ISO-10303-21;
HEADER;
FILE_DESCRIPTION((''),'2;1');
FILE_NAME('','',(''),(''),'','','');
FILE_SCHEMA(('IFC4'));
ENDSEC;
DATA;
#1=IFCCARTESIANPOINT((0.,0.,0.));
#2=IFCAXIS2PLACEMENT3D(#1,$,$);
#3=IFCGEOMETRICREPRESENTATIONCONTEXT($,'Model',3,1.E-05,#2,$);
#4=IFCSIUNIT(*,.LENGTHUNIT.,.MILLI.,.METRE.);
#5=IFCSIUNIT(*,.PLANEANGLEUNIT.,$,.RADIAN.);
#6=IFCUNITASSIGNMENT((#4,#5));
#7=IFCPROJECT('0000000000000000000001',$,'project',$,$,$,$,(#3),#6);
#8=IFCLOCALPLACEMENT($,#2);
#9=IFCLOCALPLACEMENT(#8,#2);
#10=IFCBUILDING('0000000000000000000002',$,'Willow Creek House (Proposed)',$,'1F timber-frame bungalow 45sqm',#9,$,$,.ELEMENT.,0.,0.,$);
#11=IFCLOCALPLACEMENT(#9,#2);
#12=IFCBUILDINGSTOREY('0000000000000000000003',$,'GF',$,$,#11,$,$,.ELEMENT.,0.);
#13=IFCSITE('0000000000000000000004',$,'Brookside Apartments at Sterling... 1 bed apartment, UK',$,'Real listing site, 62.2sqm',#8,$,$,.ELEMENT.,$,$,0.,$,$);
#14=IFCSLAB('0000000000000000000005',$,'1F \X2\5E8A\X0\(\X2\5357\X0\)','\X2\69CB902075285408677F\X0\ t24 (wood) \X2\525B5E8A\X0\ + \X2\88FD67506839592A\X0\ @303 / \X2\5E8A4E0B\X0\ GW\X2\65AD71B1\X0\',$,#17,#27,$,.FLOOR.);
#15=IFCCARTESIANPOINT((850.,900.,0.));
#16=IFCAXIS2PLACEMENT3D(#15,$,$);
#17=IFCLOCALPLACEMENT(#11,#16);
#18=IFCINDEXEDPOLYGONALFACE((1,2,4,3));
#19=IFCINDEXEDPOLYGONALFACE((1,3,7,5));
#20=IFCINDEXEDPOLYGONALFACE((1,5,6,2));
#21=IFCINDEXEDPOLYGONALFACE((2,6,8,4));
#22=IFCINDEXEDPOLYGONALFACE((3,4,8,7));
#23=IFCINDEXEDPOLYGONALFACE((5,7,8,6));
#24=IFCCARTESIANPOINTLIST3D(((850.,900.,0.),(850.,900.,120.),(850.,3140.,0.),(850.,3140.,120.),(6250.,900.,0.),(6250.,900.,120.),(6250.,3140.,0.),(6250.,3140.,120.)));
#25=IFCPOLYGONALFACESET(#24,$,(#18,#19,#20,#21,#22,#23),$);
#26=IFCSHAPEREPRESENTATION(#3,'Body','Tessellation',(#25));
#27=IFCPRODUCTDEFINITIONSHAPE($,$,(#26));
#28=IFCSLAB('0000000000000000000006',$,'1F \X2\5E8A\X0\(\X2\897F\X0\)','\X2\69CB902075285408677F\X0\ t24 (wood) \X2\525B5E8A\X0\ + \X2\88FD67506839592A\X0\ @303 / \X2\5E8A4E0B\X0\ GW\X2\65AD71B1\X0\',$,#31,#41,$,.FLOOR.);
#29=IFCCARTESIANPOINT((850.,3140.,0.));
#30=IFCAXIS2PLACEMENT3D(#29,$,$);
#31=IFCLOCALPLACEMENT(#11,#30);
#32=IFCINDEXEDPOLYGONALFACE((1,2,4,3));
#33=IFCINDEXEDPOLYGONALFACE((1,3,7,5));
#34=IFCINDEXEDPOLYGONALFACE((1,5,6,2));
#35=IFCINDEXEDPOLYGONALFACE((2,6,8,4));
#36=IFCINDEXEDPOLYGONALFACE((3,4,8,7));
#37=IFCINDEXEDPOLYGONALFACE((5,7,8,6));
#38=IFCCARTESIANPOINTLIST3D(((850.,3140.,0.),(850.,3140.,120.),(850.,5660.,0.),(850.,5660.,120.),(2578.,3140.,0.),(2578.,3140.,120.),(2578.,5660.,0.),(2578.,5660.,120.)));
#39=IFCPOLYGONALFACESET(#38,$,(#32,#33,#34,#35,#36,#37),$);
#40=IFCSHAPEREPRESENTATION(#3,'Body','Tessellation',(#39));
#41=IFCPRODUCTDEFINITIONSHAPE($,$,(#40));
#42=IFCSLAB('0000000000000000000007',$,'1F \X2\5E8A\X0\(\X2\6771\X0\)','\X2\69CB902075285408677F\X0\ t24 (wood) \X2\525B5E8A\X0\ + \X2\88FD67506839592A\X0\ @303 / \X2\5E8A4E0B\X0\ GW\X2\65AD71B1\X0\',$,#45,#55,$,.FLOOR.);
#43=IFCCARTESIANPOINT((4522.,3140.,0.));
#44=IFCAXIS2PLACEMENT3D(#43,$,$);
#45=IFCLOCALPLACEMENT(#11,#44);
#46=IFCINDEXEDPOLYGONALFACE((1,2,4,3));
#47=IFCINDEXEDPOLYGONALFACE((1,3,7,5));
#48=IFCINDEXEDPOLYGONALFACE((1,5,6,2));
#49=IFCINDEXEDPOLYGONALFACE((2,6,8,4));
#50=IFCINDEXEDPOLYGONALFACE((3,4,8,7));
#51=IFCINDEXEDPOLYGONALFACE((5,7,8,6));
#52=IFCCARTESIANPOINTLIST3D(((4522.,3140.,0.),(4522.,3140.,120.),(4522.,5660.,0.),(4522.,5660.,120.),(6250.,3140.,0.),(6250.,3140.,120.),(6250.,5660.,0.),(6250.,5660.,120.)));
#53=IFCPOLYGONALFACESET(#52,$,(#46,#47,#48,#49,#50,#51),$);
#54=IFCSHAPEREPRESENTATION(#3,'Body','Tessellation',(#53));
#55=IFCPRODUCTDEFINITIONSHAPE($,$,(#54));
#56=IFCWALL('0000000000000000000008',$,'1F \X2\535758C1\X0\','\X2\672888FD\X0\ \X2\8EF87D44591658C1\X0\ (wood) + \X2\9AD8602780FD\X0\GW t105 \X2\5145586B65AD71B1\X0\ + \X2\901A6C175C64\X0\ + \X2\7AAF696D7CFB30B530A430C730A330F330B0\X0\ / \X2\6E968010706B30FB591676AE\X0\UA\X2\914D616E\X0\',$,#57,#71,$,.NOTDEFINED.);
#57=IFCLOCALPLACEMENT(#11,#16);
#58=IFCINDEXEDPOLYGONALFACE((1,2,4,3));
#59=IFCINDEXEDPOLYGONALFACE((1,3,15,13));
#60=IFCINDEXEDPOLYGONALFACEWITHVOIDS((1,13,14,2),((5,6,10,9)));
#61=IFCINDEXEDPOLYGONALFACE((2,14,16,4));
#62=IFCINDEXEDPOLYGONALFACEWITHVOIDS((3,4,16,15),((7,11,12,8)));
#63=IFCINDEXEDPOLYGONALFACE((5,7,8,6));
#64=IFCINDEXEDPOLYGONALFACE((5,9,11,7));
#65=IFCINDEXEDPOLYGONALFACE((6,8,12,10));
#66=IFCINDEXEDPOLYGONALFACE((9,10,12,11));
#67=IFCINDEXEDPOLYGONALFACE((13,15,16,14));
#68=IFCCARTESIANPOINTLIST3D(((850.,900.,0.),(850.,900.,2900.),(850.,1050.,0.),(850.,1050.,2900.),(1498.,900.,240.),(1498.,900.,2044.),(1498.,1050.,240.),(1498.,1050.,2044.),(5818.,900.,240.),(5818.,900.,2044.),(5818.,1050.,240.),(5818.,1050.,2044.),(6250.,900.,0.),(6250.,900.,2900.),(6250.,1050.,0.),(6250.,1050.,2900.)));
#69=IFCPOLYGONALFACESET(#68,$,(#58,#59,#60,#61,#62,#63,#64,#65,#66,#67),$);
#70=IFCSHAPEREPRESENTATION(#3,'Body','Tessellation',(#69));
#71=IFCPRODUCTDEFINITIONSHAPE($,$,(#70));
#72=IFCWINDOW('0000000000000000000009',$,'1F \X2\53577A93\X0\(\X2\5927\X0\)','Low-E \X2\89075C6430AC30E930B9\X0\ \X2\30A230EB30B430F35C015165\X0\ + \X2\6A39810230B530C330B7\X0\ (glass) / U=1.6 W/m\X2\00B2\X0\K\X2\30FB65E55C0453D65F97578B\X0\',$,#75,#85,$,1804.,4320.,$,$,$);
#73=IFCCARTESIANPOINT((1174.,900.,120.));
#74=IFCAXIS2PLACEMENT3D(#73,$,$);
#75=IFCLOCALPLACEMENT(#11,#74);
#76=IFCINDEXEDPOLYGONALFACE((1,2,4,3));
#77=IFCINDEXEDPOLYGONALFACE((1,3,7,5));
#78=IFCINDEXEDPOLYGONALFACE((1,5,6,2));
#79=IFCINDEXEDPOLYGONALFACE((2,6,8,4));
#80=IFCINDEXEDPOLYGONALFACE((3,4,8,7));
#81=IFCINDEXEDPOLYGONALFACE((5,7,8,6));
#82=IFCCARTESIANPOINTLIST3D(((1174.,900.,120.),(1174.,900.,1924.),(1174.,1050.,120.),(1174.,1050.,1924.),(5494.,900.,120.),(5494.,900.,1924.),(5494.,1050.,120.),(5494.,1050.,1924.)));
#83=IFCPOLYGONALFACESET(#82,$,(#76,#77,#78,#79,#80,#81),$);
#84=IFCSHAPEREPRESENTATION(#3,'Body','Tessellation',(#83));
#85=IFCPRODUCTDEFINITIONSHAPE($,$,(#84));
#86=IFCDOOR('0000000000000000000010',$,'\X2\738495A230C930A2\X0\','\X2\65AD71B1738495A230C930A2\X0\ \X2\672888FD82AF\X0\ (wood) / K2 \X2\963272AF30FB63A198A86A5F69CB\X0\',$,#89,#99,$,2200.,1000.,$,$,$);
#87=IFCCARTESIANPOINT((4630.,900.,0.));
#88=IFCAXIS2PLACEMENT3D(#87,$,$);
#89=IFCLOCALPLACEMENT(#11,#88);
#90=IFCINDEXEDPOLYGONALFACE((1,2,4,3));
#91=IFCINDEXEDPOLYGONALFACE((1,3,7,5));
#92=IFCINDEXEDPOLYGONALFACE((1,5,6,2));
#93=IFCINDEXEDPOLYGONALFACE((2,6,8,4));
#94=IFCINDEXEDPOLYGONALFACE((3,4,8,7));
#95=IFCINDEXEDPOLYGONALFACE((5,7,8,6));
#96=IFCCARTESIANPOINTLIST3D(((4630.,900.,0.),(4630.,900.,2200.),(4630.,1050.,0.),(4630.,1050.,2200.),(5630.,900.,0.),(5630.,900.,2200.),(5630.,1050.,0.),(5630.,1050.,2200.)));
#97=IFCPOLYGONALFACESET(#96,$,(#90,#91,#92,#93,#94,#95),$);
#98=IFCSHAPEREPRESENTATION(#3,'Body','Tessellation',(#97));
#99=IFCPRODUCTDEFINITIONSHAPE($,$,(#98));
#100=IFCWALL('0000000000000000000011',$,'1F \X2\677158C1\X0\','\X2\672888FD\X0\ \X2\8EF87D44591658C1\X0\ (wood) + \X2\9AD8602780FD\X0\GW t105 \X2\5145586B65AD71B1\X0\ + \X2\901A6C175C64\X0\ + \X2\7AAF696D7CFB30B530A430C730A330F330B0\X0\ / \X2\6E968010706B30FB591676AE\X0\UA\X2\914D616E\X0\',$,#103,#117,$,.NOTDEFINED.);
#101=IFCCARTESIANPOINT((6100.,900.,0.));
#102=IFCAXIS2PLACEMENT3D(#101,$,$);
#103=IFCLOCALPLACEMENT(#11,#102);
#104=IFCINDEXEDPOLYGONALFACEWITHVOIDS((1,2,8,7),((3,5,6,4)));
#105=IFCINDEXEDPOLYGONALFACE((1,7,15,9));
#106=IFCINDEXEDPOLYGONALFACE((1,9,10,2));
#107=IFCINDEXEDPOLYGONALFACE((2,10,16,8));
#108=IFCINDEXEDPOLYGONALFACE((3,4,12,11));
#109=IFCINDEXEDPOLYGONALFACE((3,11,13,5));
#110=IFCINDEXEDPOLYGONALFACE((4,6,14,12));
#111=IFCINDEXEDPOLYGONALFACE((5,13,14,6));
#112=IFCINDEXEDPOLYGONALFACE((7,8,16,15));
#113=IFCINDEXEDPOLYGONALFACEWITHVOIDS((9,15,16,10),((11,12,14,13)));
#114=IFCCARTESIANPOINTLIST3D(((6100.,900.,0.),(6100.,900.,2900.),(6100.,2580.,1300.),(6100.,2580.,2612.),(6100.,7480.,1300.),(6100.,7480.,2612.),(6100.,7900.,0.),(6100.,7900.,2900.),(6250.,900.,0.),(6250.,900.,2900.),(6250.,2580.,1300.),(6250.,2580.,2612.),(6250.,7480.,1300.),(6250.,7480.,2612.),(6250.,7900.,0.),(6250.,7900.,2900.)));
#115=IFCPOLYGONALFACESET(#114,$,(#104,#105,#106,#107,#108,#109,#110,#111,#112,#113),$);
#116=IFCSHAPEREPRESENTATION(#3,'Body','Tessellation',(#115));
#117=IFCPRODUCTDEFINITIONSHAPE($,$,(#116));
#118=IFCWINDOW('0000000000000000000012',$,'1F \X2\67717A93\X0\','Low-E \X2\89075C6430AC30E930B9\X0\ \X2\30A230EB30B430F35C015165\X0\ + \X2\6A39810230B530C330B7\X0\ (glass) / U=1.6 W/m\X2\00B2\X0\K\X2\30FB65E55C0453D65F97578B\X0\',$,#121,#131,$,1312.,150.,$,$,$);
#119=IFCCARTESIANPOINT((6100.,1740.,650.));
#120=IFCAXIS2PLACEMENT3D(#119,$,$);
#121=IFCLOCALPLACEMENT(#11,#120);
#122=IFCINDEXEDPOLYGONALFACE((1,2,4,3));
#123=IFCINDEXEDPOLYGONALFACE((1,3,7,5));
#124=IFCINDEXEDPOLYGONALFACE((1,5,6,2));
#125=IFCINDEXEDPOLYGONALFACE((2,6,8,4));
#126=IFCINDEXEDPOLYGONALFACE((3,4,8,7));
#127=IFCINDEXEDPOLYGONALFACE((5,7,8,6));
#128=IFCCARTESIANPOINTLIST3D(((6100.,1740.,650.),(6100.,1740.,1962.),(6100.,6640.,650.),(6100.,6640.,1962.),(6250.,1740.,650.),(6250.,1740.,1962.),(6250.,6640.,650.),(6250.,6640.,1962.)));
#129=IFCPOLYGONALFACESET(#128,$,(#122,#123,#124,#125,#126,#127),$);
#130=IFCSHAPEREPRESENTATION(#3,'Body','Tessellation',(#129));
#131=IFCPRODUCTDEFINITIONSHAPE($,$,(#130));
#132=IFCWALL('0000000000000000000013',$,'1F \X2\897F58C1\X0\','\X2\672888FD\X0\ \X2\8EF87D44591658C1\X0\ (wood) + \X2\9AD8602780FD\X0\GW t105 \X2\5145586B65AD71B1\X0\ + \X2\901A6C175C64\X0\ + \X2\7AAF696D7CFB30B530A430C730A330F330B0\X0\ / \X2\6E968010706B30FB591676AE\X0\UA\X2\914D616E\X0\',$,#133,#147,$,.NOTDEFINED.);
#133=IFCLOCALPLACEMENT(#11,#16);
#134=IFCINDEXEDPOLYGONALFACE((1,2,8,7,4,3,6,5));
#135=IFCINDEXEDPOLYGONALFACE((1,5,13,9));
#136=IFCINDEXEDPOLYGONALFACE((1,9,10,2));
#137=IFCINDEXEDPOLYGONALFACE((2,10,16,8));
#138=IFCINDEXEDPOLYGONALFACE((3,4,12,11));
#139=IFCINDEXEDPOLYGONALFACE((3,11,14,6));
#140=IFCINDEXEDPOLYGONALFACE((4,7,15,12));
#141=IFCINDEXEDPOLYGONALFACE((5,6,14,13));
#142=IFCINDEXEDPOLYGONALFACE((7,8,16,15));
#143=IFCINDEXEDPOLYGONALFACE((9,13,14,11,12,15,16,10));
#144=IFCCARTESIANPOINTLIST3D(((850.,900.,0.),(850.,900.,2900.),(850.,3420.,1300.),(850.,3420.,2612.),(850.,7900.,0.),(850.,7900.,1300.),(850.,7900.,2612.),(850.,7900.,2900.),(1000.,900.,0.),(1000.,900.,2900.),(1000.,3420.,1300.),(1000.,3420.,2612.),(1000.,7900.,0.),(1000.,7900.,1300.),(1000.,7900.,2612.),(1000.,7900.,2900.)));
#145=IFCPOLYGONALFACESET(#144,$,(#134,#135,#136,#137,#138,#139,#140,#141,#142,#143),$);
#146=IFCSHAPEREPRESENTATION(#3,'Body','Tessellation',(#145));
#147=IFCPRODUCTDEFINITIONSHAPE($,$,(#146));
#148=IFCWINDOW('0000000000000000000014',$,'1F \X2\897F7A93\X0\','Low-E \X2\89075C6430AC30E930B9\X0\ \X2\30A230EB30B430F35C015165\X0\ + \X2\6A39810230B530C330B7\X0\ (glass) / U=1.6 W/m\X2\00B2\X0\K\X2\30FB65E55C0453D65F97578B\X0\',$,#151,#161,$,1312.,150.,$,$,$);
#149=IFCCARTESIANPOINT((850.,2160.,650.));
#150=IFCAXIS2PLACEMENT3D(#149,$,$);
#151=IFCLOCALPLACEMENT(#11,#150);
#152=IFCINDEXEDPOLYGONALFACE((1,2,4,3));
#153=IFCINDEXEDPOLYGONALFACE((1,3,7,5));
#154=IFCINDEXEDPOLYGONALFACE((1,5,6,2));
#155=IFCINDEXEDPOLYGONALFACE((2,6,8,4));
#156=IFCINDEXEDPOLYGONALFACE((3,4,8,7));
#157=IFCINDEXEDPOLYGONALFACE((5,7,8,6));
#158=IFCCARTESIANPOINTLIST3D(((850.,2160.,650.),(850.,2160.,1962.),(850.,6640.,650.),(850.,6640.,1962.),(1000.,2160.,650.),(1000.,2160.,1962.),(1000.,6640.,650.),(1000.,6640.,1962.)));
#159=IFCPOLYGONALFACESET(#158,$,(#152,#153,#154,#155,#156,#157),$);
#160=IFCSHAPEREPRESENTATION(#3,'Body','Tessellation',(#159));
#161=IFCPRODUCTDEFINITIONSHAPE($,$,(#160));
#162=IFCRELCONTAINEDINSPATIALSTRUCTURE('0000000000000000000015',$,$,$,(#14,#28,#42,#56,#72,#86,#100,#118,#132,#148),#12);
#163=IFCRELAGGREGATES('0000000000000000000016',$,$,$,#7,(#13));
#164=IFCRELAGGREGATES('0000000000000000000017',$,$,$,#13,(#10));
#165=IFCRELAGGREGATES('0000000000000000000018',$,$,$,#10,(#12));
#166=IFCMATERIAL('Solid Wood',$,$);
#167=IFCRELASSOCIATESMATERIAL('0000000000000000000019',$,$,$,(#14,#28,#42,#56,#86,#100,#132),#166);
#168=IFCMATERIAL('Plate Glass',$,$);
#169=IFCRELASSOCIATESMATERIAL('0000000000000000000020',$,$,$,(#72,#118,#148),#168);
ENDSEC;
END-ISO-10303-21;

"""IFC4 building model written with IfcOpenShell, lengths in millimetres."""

from ifc_helpers import new_model, si_unit, frame, frame_2d, origin, place, context, project, spatial, rectangle, extrude, material, element, fill, save


model = new_model("IFC4")

# Units and contexts
model_context = context("Model", 3, precision=1e-05, world=origin())
ifc_project = project(units=[si_unit("LENGTHUNIT", "METRE", prefix="MILLI"), si_unit("PLANEANGLEUNIT", "RADIAN")], contexts=[model_context])

# Site, building, storey
site_placement = place(None, origin())
site = spatial("IfcSite", under=ifc_project, at=site_placement, Name="Brookside Apartments at Sterling... 1 bed apartment, UK", ObjectType="Real listing site, 62.2sqm", CompositionType="ELEMENT", RefElevation=0.0)
building_placement = place(site_placement, origin())
building = spatial("IfcBuilding", under=site, at=building_placement, Name="Willow Creek House (Proposed)", ObjectType="1F timber-frame bungalow 45sqm", CompositionType="ELEMENT", ElevationOfRefHeight=0.0, ElevationOfTerrain=0.0)
storey_placement = place(building_placement, origin())
storey = spatial("IfcBuildingStorey", under=building, at=storey_placement, Name="GF", CompositionType="ELEMENT", Elevation=0.0)

# Slabs
ifc_material_1 = material(Name="Solid Wood")
slab_1_placement = place(storey_placement, frame((850.0, 900.0, 0.0)))
element("IfcSlab", 1, at=slab_1_placement, inside=storey, material=ifc_material_1, Name="1F 床(南)", Description="構造用合板 t24 (wood) 剛床 + 製材根太 @303 / 床下 GW断熱", PredefinedType="FLOOR", context=model_context, shape_type="SweptSolid", body=[
    extrude(rectangle(XDim=5400.0, YDim=2240.0, at=frame_2d((2700.0, 1120.0))), frame((850.0, 900.0, 0.0)), (0.0, 0.0, 1.0), 120.0),
])
slab_2_placement = place(storey_placement, frame((850.0, 3140.0, 0.0)))
element("IfcSlab", 2, at=slab_2_placement, inside=storey, material=ifc_material_1, Name="1F 床(西)", Description="構造用合板 t24 (wood) 剛床 + 製材根太 @303 / 床下 GW断熱", PredefinedType="FLOOR", context=model_context, shape_type="SweptSolid", body=[
    extrude(rectangle(XDim=1728.0, YDim=2520.0, at=frame_2d((864.0, 1260.0))), frame((850.0, 3140.0, 0.0)), (0.0, 0.0, 1.0), 120.0),
])
slab_3_placement = place(storey_placement, frame((4522.0, 3140.0, 0.0)))
element("IfcSlab", 3, at=slab_3_placement, inside=storey, material=ifc_material_1, Name="1F 床(東)", Description="構造用合板 t24 (wood) 剛床 + 製材根太 @303 / 床下 GW断熱", PredefinedType="FLOOR", context=model_context, shape_type="SweptSolid", body=[
    extrude(rectangle(XDim=1728.0, YDim=2520.0, at=frame_2d((864.0, 1260.0))), frame((4522.0, 3140.0, 0.0)), (0.0, 0.0, 1.0), 120.0),
])

# Wall, openings, window, door
wall_1_placement = place(storey_placement, frame((850.0, 900.0, 0.0)))
wall_1 = element("IfcWall", 4, at=wall_1_placement, inside=storey, material=ifc_material_1, Name="1F 南壁", Description="木製 軸組外壁 (wood) + 高性能GW t105 充填断熱 + 通気層 + 窯業系サイディング / 準耐火・外皮UA配慮", PredefinedType="NOTDEFINED", context=model_context, shape_type="SweptSolid", body=[
    extrude(rectangle(XDim=5400.0, YDim=150.0, at=frame_2d((2700.0, 75.0))), frame((850.0, 900.0, 0.0)), (0.0, 0.0, 1.0), 2900.0),
])
opening_1_placement = place(storey_placement, frame((1174.0, 900.0, 120.0)))
opening_1 = element("IfcOpeningElement", 5, at=opening_1_placement, cuts=wall_1, PredefinedType="NOTDEFINED", context=model_context, shape_type="SweptSolid", body=[
    extrude(rectangle(XDim=4320.0, YDim=150.0, at=frame_2d((2160.0, 75.0))), frame((1174.0, 900.0, 120.0)), (0.0, 0.0, 1.0), 1804.0),
])
opening_2_placement = place(storey_placement, frame((4630.0, 900.0, 0.0)))
opening_2 = element("IfcOpeningElement", 6, at=opening_2_placement, cuts=wall_1, PredefinedType="NOTDEFINED", context=model_context, shape_type="SweptSolid", body=[
    extrude(rectangle(XDim=1000.0, YDim=150.0, at=frame_2d((500.0, 75.0))), frame((4630.0, 900.0, 0.0)), (0.0, 0.0, 1.0), 2200.0),
])
ifc_material_2 = material(Name="Plate Glass")
window_1_placement = place(storey_placement, frame((1174.0, 900.0, 120.0)))
window_1 = element("IfcWindow", 7, at=window_1_placement, inside=storey, material=ifc_material_2, Name="1F 南窓(大)", Description="Low-E 複層ガラス アルゴン封入 + 樹脂サッシ (glass) / U=1.6 W/m²K・日射取得型", OverallHeight=1804.0, OverallWidth=4320.0, context=model_context, shape_type="SweptSolid", body=[
    extrude(rectangle(XDim=4320.0, YDim=150.0, at=frame_2d((2160.0, 75.0))), frame((1174.0, 900.0, 120.0)), (0.0, 0.0, 1.0), 1804.0),
])
fill(opening_1, window_1)
door_placement = place(storey_placement, frame((4630.0, 900.0, 0.0)))
door = element("IfcDoor", 8, at=door_placement, inside=storey, material=ifc_material_1, Name="玄関ドア", Description="断熱玄関ドア 木製芯 (wood) / K2 防犯・採風機構", OverallHeight=2200.0, OverallWidth=1000.0, context=model_context, shape_type="SweptSolid", body=[
    extrude(rectangle(XDim=1000.0, YDim=150.0, at=frame_2d((500.0, 75.0))), frame((4630.0, 900.0, 0.0)), (0.0, 0.0, 1.0), 2200.0),
])
fill(opening_2, door)

# Walls, openings, windows
wall_2_placement = place(storey_placement, frame((6100.0, 900.0, 0.0)))
wall_2 = element("IfcWall", 9, at=wall_2_placement, inside=storey, material=ifc_material_1, Name="1F 東壁", Description="木製 軸組外壁 (wood) + 高性能GW t105 充填断熱 + 通気層 + 窯業系サイディング / 準耐火・外皮UA配慮", PredefinedType="NOTDEFINED", context=model_context, shape_type="SweptSolid", body=[
    extrude(rectangle(XDim=150.0, YDim=7000.0, at=frame_2d((75.0, 3500.0))), frame((6100.0, 900.0, 0.0)), (0.0, 0.0, 1.0), 2900.0),
])
opening_3_placement = place(storey_placement, frame((6100.0, 1740.0, 650.0)))
opening_3 = element("IfcOpeningElement", 10, at=opening_3_placement, cuts=wall_2, PredefinedType="NOTDEFINED", context=model_context, shape_type="SweptSolid", body=[
    extrude(rectangle(XDim=150.0, YDim=4900.0, at=frame_2d((75.0, 2450.0))), frame((6100.0, 1740.0, 650.0)), (0.0, 0.0, 1.0), 1312.0),
])
window_2_placement = place(storey_placement, frame((6100.0, 1740.0, 650.0)))
window_2 = element("IfcWindow", 11, at=window_2_placement, inside=storey, material=ifc_material_2, Name="1F 東窓", Description="Low-E 複層ガラス アルゴン封入 + 樹脂サッシ (glass) / U=1.6 W/m²K・日射取得型", OverallHeight=1312.0, OverallWidth=150.0, context=model_context, shape_type="SweptSolid", body=[
    extrude(rectangle(XDim=150.0, YDim=4900.0, at=frame_2d((75.0, 2450.0))), frame((6100.0, 1740.0, 650.0)), (0.0, 0.0, 1.0), 1312.0),
])
fill(opening_3, window_2)
wall_3_placement = place(storey_placement, frame((850.0, 900.0, 0.0)))
wall_3 = element("IfcWall", 12, at=wall_3_placement, inside=storey, material=ifc_material_1, Name="1F 西壁", Description="木製 軸組外壁 (wood) + 高性能GW t105 充填断熱 + 通気層 + 窯業系サイディング / 準耐火・外皮UA配慮", PredefinedType="NOTDEFINED", context=model_context, shape_type="SweptSolid", body=[
    extrude(rectangle(XDim=150.0, YDim=7000.0, at=frame_2d((75.0, 3500.0))), frame((850.0, 900.0, 0.0)), (0.0, 0.0, 1.0), 2900.0),
])
opening_4_placement = place(storey_placement, frame((850.0, 2160.0, 650.0)))
opening_4 = element("IfcOpeningElement", 13, at=opening_4_placement, cuts=wall_3, PredefinedType="NOTDEFINED", context=model_context, shape_type="SweptSolid", body=[
    extrude(rectangle(XDim=150.0, YDim=4480.0, at=frame_2d((75.0, 2240.0))), frame((850.0, 2160.0, 650.0)), (0.0, 0.0, 1.0), 1312.0),
])
window_3_placement = place(storey_placement, frame((850.0, 2160.0, 650.0)))
window_3 = element("IfcWindow", 14, at=window_3_placement, inside=storey, material=ifc_material_2, Name="1F 西窓", Description="Low-E 複層ガラス アルゴン封入 + 樹脂サッシ (glass) / U=1.6 W/m²K・日射取得型", OverallHeight=1312.0, OverallWidth=150.0, context=model_context, shape_type="SweptSolid", body=[
    extrude(rectangle(XDim=150.0, YDim=4480.0, at=frame_2d((75.0, 2240.0))), frame((850.0, 2160.0, 650.0)), (0.0, 0.0, 1.0), 1312.0),
])
fill(opening_4, window_3)

save(model, "model.ifc")
